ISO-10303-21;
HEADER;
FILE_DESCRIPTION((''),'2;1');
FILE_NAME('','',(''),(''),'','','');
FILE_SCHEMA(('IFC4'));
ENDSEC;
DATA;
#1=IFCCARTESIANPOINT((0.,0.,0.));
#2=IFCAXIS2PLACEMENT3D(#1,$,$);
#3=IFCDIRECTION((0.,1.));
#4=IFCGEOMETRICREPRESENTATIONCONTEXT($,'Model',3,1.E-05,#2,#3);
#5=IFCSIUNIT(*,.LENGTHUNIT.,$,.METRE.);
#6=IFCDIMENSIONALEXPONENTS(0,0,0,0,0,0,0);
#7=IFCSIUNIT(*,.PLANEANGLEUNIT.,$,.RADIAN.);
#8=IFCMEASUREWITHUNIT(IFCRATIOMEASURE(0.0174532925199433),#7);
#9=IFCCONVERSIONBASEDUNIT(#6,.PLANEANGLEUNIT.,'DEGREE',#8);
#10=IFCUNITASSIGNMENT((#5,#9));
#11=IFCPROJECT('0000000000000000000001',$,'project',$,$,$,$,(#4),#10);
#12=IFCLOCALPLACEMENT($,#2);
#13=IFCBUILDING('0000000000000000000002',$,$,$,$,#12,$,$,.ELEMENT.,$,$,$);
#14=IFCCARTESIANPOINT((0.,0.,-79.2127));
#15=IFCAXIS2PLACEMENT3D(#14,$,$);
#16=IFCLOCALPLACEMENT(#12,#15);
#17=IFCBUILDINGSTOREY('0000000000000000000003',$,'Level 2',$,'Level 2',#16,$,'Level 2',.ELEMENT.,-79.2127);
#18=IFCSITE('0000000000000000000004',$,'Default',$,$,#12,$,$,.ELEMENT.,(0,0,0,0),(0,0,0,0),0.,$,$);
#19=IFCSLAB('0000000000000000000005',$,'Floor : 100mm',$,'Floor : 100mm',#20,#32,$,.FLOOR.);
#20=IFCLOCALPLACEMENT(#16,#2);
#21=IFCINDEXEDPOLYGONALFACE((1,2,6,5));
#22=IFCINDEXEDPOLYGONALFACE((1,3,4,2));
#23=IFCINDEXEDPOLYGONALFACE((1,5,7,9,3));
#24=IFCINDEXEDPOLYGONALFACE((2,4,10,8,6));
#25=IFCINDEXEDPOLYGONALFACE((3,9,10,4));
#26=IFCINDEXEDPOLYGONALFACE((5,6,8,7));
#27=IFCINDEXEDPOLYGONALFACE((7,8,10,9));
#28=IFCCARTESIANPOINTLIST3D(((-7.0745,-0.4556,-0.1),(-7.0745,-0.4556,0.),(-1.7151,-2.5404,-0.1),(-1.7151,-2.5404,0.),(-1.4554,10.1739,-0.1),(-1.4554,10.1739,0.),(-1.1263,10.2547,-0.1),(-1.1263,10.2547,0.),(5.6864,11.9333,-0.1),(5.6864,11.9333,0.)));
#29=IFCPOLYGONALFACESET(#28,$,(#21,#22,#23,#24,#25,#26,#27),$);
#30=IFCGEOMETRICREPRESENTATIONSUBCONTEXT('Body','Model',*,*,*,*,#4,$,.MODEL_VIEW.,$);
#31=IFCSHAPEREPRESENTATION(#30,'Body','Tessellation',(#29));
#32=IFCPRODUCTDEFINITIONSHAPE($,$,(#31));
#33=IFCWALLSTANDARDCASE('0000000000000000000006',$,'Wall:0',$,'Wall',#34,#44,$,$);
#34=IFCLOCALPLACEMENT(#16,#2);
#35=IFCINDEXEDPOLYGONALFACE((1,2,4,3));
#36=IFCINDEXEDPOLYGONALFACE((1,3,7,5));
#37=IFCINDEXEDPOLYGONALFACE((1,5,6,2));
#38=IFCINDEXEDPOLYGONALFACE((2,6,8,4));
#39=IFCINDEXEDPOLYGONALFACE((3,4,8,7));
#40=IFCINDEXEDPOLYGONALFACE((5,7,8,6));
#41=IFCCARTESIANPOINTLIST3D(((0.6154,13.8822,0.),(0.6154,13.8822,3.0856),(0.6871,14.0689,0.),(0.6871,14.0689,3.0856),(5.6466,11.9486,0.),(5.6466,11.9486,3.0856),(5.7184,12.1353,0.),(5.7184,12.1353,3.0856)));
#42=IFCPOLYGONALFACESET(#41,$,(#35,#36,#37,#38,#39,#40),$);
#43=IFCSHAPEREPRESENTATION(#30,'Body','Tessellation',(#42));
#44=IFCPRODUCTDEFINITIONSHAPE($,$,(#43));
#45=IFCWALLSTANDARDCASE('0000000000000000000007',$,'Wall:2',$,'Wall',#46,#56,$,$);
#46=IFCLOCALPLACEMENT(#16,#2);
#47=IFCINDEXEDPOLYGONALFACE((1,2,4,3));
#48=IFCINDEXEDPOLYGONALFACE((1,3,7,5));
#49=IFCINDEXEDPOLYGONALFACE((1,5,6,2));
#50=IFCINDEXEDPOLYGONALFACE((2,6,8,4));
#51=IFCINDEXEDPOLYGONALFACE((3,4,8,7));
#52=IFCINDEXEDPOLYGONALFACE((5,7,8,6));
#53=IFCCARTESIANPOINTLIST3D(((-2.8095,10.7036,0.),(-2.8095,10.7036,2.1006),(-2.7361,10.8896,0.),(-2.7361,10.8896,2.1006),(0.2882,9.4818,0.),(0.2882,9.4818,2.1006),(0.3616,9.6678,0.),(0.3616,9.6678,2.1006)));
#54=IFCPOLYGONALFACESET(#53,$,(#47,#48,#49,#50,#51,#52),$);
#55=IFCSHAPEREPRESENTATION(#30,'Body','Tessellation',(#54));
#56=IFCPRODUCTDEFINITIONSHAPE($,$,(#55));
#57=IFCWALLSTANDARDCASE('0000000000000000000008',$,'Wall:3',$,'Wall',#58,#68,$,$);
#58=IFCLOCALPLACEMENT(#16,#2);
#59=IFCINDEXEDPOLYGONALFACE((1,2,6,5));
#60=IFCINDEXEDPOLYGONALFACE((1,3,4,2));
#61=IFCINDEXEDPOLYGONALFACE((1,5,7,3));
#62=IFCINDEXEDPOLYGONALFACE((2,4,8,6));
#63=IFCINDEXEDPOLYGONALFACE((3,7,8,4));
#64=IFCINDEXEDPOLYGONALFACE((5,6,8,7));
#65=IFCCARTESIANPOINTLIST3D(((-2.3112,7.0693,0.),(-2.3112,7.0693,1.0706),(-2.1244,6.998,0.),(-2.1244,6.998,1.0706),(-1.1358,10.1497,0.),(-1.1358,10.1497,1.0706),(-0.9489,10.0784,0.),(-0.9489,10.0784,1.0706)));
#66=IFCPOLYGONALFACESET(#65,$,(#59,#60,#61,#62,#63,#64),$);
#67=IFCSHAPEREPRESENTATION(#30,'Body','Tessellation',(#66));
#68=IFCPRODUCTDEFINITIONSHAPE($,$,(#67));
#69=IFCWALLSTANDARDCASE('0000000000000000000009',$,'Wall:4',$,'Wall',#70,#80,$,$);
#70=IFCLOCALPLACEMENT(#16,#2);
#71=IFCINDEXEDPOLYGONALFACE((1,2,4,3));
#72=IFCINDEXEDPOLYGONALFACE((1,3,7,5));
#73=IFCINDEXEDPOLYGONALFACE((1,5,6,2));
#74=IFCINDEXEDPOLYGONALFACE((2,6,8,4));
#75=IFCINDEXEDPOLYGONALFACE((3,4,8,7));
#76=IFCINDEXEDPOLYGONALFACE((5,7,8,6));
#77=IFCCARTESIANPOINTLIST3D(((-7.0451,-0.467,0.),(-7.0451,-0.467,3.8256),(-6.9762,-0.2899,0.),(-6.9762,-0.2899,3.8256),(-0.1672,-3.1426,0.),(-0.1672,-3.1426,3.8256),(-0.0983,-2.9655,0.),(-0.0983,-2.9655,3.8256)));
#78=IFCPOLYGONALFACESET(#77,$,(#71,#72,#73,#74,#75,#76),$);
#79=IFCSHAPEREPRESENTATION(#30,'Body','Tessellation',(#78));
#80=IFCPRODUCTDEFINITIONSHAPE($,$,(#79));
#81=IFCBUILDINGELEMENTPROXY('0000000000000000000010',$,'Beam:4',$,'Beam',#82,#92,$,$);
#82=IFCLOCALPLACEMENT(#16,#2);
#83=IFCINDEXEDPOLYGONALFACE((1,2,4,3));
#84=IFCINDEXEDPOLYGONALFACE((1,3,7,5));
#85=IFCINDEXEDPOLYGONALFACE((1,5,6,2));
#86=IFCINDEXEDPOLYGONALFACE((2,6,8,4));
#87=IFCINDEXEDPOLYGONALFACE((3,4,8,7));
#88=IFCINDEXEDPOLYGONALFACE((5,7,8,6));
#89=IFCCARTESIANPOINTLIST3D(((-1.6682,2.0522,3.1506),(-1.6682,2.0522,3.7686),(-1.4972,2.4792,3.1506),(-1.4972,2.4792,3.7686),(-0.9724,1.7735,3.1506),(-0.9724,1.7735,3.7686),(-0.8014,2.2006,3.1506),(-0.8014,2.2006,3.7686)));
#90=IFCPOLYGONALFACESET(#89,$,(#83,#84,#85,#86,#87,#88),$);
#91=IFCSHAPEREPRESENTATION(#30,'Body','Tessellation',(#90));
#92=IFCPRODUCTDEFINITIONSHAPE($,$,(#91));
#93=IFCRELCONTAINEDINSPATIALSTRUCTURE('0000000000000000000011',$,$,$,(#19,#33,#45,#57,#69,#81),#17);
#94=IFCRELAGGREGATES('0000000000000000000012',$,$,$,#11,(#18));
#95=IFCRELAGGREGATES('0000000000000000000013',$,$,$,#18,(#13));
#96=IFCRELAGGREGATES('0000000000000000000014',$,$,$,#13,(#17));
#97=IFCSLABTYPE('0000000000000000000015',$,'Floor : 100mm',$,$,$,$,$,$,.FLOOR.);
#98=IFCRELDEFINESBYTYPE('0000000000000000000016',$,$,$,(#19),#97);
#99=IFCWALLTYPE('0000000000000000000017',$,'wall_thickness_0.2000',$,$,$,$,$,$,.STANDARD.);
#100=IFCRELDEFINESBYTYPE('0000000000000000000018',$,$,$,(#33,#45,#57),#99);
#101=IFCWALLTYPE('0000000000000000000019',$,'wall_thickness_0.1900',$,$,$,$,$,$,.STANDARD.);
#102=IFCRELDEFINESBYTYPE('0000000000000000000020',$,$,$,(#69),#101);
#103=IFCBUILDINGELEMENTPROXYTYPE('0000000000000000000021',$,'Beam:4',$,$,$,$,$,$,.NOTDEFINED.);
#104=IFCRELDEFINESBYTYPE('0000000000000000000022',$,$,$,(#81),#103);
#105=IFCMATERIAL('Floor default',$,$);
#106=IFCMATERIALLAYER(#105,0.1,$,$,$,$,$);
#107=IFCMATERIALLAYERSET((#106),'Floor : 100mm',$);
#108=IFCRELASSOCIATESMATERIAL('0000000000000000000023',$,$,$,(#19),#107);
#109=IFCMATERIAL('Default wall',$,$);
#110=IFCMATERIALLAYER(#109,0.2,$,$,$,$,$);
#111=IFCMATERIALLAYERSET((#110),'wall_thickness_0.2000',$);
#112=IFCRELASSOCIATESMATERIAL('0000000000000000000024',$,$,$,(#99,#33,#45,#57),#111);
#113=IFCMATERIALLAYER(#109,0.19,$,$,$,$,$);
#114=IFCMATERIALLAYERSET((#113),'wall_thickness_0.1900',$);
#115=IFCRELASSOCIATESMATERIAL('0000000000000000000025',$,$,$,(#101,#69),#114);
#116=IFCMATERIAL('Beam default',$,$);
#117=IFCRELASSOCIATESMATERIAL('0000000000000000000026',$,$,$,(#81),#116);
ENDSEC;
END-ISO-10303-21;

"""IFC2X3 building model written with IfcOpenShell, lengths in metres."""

from ifc_helpers import new_model, entity, si_unit, converted_unit, direction, frame, origin, place, context, subcontext, project, spatial, polyline, outline, extrude, source, transform, mapped, material, layer, layer_set, layer_usage, type_object, type_shapes, element, save


model = new_model("IFC2X3")

# Units and contexts
model_context = context("Model", 3, precision=1e-05, world=origin(), true_north=direction((0.0, 1.0)))
body_context = subcontext(model_context, "Body", "Model", "MODEL_VIEW")
ifc_project = project(units=[si_unit("LENGTHUNIT", "METRE"), converted_unit("PLANEANGLEUNIT", "DEGREE", entity("IfcRatioMeasure", 0.0174532925199433), si_unit("PLANEANGLEUNIT", "RADIAN"), dimensions=[0, 0, 0, 0, 0, 0, 0])], contexts=[model_context])

# Site, building, storey
placement_1 = place(None, origin())
site = spatial("IfcSite", under=ifc_project, at=placement_1, Name="Default", CompositionType="ELEMENT", RefLatitude=(0, 0, 0, 0), RefLongitude=(0, 0, 0, 0), RefElevation=0.0)
building = spatial("IfcBuilding", under=site, at=placement_1, CompositionType="ELEMENT")
storey_placement = place(placement_1, frame((0.0, 0.0, -79.2127)))
storey = spatial("IfcBuildingStorey", under=building, at=storey_placement, Name="Level 2", ObjectType="Level 2", LongName="Level 2", CompositionType="ELEMENT", Elevation=-79.2127)

# Slab
ifc_material_1 = material(Name="Floor default")
ifc_layer_1 = layer(ifc_material_1, 0.1)
ifc_layer_set_1 = layer_set([ifc_layer_1], Name="Floor : 100mm")
ifc_layer_usage_1 = layer_usage(ifc_layer_set_1, "AXIS3", "POSITIVE", 0.0)
slab_type = type_object("IfcSlabType", Name="Floor : 100mm", PredefinedType="FLOOR")
slab_placement = place(storey_placement, origin())
element("IfcSlab", 1, at=slab_placement, inside=storey, type_object=slab_type, material=ifc_layer_usage_1, Name="Floor : 100mm", ObjectType="Floor : 100mm", PredefinedType="FLOOR", context=body_context, shape_type="SweptSolid", body=[
    extrude(outline(polyline([(5.6864, 11.9333), (-1.1263, 10.2547), (-1.4554, 10.1739), (-7.0745, -0.4556), (-1.7151, -2.5404), (5.6864, 11.9333)])), frame((0.0, 0.0, -0.1), z_axis=(0.0, 0.0, 1.0), x_axis=(1.0, 0.0, 0.0)), (0.0, 0.0, 1.0), 0.1),
])

# Walls
ifc_material_2 = material(Name="Default wall")
ifc_layer_2 = layer(ifc_material_2, 0.2)
ifc_layer_set_2 = layer_set([ifc_layer_2], Name="wall_thickness_0.2000")
ifc_layer_usage_2 = layer_usage(ifc_layer_set_2, "AXIS2", "POSITIVE", -0.1)
wall_type_1 = type_object("IfcWallType", Name="wall_thickness_0.2000", PredefinedType="STANDARD", material=ifc_layer_set_2)
wall_1_placement = place(storey_placement, frame((0.6513, 13.9755, 0.0), z_axis=(0.0, 0.0, 1.0), x_axis=(0.933438, -0.358739, 0.0)))
element("IfcWallStandardCase", 2, at=wall_1_placement, inside=storey, type_object=wall_type_1, material=ifc_layer_usage_2, Name="Wall:0", ObjectType="Wall", context=body_context, shape_type="SweptSolid", body=[
    extrude(outline(polyline([(5.39, -0.1), (5.39, 0.1), (0.0, 0.1), (0.0, -0.1), (5.39, -0.1)])), origin(), (0.0, 0.0, 1.0), 3.0856),
])
wall_2_placement = place(storey_placement, frame((-2.7728, 10.7966, 0.0), z_axis=(0.0, 0.0, 1.0), x_axis=(0.930256, -0.366912, 0.0)))
element("IfcWallStandardCase", 3, at=wall_2_placement, inside=storey, type_object=wall_type_1, material=ifc_layer_usage_2, Name="Wall:2", ObjectType="Wall", context=body_context, shape_type="SweptSolid", body=[
    extrude(outline(polyline([(3.33, -0.1), (3.33, 0.1), (0.0, 0.1), (0.0, -0.1), (3.33, -0.1)])), origin(), (0.0, 0.0, 1.0), 2.1006),
])
wall_3_placement = place(storey_placement, frame((-2.2178, 7.0337, 0.0), z_axis=(0.0, 0.0, 1.0), x_axis=(0.356526, 0.934285, 0.0)))
element("IfcWallStandardCase", 4, at=wall_3_placement, inside=storey, type_object=wall_type_1, material=ifc_layer_usage_2, Name="Wall:3", ObjectType="Wall", context=body_context, shape_type="SweptSolid", body=[
    extrude(outline(polyline([(3.2971, -0.1), (3.2971, 0.1), (0.0, 0.1), (0.0, -0.1), (3.2971, -0.1)])), origin(), (0.0, 0.0, 1.0), 1.0706),
])
ifc_layer_3 = layer(ifc_material_2, 0.19)
ifc_layer_set_3 = layer_set([ifc_layer_3], Name="wall_thickness_0.1900")
ifc_layer_usage_3 = layer_usage(ifc_layer_set_3, "AXIS2", "POSITIVE", -0.095)
wall_type_2 = type_object("IfcWallType", Name="wall_thickness_0.1900", PredefinedType="STANDARD", material=ifc_layer_set_3)
wall_4_placement = place(storey_placement, frame((-7.0107, -0.3785, 0.0), z_axis=(0.0, 0.0, 1.0), x_axis=(0.931965, -0.362547, 0.0)))
element("IfcWallStandardCase", 5, at=wall_4_placement, inside=storey, type_object=wall_type_2, material=ifc_layer_usage_3, Name="Wall:4", ObjectType="Wall", context=body_context, shape_type="SweptSolid", body=[
    extrude(outline(polyline([(7.38, -0.095), (7.38, 0.095), (0.0, 0.095), (0.0, -0.095), (7.38, -0.095)])), origin(), (0.0, 0.0, 1.0), 3.8256),
])

# Building element proxy
ifc_material_3 = material(Name="Beam default")
building_element_proxy_type = type_object("IfcBuildingElementProxyType", Name="Beam:4", PredefinedType="NOTDEFINED")
shared_shape = source(origin(), body_context, "Body", "SweptSolid", [
    extrude(outline(polyline([(0.7495, -0.23), (0.7495, 0.23), (0.0, 0.23), (0.0, -0.23), (0.7495, -0.23)])), origin(), (0.0, 0.0, 1.0), 0.618),
])
type_shapes(building_element_proxy_type, [shared_shape])
placement_2 = place(placement_1, frame((0.0, 0.0, -76.0621)))
proxy_placement = place(placement_2, frame((-1.5827, 2.2657, 0.0), z_axis=(0.0, 0.0, 1.0), x_axis=(0.928329, -0.371761, 0.0)))
element("IfcBuildingElementProxy", 6, at=proxy_placement, inside=storey, type_object=building_element_proxy_type, material=ifc_material_3, Name="Beam:4", ObjectType="Beam", context=body_context, shape_type="MappedRepresentation", body=[
    mapped(shared_shape, transform((0.0, 0.0, 0.0), scale=1.0)),
])

save(model, "model.ifc")
